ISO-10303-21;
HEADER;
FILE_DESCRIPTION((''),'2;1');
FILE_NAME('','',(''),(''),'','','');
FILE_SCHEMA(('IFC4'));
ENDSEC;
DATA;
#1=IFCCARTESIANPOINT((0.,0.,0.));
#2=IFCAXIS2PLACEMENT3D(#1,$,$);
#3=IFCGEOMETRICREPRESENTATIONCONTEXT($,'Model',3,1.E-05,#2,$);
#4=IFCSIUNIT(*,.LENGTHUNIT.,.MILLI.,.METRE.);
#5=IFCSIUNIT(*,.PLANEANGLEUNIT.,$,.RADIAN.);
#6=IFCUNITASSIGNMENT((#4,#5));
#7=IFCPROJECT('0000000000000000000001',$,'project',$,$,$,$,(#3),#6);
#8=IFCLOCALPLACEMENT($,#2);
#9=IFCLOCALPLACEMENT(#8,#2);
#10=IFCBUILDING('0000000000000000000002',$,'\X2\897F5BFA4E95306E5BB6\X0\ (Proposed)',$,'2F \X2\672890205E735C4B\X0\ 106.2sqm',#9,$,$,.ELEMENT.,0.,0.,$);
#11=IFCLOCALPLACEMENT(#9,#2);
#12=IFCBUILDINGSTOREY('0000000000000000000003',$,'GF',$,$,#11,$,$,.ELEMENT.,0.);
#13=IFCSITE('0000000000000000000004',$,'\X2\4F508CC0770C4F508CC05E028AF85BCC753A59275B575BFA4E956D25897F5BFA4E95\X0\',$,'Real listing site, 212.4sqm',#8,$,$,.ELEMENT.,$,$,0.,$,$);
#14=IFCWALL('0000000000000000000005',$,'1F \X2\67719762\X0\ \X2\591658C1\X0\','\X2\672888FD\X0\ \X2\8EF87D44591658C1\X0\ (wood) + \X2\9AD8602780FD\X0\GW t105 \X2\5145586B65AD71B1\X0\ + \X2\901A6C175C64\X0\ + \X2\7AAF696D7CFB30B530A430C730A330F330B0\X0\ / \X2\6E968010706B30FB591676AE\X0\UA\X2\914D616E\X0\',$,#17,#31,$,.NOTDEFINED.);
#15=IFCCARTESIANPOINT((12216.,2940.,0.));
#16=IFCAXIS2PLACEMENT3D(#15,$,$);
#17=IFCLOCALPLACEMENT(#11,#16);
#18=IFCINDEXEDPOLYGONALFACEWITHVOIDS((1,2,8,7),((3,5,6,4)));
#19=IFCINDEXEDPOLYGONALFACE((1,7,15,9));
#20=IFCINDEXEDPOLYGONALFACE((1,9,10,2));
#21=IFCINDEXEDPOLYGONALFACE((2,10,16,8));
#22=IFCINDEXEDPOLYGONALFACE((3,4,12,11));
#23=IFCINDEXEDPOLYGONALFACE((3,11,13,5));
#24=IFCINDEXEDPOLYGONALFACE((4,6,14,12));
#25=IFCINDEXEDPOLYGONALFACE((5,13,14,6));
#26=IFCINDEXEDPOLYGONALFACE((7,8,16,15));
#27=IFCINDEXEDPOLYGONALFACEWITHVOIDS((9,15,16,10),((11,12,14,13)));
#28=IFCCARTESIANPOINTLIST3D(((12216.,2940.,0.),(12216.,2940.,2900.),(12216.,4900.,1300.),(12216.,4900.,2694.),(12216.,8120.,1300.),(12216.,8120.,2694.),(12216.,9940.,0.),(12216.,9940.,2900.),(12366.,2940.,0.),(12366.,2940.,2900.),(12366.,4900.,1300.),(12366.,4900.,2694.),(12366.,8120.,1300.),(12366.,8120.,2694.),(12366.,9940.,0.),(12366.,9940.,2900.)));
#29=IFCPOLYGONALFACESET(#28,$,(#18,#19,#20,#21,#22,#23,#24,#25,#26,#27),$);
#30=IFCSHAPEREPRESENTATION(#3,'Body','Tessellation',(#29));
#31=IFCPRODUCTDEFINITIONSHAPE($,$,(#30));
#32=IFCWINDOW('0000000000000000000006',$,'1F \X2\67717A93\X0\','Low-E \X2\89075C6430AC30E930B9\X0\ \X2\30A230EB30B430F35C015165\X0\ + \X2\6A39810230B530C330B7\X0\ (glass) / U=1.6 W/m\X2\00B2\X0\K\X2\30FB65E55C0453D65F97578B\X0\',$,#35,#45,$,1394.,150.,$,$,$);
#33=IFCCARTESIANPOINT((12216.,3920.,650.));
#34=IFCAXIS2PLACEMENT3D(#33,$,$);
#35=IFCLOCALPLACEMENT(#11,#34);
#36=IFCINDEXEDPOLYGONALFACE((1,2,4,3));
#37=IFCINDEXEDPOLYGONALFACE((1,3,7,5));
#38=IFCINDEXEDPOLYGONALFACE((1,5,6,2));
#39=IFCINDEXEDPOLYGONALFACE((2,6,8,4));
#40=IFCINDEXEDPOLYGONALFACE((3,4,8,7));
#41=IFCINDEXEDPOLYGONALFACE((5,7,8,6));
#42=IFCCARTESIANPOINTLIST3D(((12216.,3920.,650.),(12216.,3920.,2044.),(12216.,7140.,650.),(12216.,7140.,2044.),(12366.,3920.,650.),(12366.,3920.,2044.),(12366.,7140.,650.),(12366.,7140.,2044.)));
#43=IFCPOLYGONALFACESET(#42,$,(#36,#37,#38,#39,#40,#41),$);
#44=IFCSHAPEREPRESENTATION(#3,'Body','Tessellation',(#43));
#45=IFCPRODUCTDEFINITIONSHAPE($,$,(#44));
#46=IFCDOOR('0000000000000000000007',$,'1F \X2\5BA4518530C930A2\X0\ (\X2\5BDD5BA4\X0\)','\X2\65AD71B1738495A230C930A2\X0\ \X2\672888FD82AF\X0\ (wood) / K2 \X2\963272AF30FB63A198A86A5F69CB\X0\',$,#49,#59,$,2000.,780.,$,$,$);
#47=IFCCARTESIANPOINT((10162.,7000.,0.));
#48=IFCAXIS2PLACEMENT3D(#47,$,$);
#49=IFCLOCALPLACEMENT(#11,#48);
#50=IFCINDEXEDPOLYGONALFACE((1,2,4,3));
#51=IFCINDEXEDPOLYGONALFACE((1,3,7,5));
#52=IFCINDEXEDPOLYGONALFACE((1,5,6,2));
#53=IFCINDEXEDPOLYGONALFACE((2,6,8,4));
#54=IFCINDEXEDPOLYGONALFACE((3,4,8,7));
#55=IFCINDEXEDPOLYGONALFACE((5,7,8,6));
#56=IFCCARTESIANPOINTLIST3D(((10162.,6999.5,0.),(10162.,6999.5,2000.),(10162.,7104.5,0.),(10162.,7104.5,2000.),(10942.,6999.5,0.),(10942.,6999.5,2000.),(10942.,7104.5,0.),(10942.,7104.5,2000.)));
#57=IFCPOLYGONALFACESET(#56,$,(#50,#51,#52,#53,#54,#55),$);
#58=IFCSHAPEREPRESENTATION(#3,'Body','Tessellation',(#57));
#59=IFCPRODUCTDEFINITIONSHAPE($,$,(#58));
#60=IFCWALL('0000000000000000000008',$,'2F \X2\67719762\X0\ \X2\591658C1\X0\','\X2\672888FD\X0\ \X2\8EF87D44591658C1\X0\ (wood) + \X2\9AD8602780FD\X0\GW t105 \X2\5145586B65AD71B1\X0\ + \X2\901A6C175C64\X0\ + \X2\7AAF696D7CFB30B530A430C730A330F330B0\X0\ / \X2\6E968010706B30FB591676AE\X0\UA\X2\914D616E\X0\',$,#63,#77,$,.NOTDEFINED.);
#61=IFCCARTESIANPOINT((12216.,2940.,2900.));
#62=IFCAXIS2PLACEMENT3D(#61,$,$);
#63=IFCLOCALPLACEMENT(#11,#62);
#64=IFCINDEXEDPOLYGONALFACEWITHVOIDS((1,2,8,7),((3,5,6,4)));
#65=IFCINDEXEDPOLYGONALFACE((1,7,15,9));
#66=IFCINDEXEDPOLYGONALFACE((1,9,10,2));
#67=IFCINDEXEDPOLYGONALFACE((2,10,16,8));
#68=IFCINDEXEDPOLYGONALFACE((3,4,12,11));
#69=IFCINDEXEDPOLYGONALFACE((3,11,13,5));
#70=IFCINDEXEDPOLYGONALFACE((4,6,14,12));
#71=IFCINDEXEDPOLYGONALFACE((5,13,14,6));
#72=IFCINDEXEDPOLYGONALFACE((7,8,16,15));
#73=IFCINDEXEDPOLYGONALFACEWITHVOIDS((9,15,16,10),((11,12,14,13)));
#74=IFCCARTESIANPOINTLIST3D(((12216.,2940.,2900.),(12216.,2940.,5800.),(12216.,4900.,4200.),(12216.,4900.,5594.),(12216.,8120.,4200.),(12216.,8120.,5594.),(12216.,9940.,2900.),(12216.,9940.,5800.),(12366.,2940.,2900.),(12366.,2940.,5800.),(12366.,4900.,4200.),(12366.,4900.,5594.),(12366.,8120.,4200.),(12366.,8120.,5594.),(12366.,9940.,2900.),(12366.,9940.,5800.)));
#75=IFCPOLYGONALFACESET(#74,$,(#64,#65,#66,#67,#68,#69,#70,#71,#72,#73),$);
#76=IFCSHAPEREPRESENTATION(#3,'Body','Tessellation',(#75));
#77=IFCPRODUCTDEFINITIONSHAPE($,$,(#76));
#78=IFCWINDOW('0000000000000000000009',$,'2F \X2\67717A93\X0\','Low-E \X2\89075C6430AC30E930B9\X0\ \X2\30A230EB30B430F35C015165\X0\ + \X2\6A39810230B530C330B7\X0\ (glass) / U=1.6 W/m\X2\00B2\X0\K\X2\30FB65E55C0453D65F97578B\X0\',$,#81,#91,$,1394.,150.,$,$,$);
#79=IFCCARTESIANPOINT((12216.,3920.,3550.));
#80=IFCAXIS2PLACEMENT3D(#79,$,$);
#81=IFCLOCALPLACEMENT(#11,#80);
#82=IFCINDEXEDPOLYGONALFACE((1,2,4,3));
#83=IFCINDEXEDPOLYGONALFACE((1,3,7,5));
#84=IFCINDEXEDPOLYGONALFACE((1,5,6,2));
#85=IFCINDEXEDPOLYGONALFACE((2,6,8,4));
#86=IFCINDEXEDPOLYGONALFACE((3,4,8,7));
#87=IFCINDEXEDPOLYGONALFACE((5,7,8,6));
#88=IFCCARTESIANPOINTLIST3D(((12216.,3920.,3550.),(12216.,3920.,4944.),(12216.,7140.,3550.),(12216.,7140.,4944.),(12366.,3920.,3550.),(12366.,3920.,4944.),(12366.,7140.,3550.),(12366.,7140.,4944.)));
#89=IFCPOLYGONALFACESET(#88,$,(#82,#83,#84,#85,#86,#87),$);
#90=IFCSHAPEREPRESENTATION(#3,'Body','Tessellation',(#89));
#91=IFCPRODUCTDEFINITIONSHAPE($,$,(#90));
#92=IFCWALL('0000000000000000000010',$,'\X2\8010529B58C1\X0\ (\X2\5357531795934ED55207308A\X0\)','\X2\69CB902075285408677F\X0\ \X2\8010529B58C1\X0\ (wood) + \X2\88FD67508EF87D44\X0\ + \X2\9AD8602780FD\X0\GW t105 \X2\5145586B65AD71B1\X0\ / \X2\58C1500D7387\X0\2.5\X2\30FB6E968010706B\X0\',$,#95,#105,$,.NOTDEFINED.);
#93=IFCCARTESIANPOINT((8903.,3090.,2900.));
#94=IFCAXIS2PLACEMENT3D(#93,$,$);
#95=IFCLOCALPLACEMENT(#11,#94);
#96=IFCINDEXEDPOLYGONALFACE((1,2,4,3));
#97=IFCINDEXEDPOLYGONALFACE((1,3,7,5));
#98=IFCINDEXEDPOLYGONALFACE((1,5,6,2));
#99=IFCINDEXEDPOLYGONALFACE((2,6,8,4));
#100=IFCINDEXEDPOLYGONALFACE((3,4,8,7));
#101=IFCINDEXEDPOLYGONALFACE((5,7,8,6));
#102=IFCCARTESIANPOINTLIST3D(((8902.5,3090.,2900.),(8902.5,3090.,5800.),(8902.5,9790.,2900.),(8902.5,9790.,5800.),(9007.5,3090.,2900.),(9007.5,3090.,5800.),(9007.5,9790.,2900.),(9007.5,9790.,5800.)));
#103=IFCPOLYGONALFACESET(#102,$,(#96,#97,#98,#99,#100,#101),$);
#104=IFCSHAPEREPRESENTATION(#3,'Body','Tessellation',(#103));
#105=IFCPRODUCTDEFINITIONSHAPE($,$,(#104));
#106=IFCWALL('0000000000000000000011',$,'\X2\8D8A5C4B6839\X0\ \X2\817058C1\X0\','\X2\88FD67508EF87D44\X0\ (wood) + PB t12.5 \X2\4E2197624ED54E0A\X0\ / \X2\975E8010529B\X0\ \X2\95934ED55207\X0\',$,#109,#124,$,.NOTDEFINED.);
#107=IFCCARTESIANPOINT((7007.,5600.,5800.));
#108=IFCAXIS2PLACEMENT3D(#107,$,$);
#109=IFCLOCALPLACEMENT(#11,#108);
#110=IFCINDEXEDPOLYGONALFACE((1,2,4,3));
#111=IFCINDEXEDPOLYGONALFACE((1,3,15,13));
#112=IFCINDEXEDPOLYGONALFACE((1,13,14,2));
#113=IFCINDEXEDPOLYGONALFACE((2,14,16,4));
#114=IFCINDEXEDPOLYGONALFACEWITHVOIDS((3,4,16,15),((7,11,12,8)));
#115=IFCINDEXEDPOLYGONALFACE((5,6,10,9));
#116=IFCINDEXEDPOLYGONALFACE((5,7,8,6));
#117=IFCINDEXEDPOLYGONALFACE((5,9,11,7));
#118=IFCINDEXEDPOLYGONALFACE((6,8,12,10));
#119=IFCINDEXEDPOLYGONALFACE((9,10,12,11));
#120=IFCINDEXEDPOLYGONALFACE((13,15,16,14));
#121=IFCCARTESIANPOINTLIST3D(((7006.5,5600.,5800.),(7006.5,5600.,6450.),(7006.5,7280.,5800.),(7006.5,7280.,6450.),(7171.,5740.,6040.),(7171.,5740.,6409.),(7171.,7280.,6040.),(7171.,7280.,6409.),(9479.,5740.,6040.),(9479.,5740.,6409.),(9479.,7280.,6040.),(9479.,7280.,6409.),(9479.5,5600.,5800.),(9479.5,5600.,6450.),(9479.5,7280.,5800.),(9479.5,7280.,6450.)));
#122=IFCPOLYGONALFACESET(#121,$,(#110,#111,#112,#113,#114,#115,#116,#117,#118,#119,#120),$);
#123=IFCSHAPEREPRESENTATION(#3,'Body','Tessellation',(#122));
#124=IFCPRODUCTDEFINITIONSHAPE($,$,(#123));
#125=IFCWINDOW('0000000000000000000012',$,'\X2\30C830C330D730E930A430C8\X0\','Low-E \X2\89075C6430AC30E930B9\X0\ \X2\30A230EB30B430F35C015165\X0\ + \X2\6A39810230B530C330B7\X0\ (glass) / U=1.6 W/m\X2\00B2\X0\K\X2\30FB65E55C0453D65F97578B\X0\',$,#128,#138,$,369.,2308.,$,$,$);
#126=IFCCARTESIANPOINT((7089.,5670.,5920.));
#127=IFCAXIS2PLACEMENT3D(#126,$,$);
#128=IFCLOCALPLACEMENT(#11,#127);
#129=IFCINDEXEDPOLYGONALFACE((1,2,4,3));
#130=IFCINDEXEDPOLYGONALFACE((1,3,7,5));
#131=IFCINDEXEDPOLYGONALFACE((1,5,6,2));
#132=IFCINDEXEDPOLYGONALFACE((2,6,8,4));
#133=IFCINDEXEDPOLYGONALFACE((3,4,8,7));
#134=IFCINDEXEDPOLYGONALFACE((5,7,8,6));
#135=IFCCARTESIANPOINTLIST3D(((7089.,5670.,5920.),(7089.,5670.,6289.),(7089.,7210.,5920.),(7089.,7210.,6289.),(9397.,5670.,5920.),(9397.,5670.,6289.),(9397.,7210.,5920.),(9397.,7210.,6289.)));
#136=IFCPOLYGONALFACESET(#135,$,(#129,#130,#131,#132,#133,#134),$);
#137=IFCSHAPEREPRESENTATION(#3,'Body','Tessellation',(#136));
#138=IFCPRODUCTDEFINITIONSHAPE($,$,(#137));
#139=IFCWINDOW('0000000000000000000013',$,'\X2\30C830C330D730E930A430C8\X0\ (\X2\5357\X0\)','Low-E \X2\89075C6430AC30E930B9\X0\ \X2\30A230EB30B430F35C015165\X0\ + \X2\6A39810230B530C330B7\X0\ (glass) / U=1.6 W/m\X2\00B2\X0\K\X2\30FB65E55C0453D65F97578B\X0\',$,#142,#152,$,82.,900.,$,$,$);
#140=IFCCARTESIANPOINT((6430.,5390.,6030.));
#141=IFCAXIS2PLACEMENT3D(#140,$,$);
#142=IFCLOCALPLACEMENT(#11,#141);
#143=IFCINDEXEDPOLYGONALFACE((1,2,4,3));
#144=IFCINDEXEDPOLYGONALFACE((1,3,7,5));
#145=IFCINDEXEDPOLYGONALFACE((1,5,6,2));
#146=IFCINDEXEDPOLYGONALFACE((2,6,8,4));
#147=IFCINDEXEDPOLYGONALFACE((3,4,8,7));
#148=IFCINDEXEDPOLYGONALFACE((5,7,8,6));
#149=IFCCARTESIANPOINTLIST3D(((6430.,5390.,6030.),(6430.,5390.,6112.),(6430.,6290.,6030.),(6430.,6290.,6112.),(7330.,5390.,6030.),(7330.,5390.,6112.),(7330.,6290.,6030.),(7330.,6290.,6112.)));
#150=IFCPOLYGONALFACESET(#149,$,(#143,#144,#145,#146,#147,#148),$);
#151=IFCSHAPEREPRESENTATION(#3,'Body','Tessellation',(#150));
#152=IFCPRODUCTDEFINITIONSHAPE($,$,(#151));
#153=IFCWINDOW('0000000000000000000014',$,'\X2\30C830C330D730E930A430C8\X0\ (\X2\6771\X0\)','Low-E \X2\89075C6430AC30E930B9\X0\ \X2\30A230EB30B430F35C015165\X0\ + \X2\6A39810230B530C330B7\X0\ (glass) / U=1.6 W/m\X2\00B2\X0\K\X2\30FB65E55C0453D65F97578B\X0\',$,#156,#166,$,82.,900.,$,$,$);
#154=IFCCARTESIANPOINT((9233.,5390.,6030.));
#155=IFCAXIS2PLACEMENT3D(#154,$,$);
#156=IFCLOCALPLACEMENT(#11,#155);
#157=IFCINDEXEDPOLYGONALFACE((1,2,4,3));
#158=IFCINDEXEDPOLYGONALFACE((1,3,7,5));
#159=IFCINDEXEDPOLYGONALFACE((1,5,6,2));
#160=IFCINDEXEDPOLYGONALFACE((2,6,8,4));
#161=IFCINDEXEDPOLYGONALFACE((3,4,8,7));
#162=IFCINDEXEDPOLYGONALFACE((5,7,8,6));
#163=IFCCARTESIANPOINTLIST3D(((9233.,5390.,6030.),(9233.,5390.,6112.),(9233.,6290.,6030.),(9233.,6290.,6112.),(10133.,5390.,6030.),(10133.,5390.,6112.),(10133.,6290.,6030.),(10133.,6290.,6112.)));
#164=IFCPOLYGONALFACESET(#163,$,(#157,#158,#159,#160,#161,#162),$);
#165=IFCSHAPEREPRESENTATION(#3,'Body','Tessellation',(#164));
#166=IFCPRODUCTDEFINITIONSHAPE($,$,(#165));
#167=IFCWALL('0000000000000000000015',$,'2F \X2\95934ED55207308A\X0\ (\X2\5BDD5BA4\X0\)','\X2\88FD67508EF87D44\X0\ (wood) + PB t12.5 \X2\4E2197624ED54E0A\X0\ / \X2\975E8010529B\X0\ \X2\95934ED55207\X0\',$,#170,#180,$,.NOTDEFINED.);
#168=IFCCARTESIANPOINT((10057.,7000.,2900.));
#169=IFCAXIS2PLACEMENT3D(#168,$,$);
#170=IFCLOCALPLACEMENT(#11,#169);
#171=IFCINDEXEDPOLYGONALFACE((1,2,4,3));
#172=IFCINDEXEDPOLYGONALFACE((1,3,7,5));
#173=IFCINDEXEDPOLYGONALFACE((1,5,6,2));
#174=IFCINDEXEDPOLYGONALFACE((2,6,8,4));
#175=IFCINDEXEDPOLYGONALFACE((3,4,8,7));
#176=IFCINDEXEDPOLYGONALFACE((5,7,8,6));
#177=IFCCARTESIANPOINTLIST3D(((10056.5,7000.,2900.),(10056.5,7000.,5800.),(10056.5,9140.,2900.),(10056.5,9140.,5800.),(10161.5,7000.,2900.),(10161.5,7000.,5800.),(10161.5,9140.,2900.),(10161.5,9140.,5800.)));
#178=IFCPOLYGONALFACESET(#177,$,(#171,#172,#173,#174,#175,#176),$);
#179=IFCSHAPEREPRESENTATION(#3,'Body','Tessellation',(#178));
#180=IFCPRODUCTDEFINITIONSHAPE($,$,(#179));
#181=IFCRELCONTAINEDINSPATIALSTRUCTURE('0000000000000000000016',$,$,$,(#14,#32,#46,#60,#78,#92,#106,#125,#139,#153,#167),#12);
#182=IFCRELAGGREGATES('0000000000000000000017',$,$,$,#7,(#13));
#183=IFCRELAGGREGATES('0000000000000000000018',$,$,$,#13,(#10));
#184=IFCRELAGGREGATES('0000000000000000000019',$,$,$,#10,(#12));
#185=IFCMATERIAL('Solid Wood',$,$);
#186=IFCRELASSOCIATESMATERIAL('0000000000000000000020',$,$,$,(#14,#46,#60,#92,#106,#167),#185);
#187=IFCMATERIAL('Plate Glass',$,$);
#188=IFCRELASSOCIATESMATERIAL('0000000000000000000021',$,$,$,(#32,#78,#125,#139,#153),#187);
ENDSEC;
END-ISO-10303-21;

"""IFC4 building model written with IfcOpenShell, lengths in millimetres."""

from ifc_helpers import new_model, si_unit, frame, frame_2d, origin, place, context, project, spatial, rectangle, extrude, material, element, fill, save


model = new_model("IFC4")

# Units and contexts
model_context = context("Model", 3, precision=1e-05, world=origin())
ifc_project = project(units=[si_unit("LENGTHUNIT", "METRE", prefix="MILLI"), si_unit("PLANEANGLEUNIT", "RADIAN")], contexts=[model_context])

# Site, building, storey
site_placement = place(None, origin())
site = spatial("IfcSite", under=ifc_project, at=site_placement, Name="佐賀県佐賀市諸富町大字寺井津西寺井", ObjectType="Real listing site, 212.4sqm", CompositionType="ELEMENT", RefElevation=0.0)
building_placement = place(site_placement, origin())
building = spatial("IfcBuilding", under=site, at=building_placement, Name="西寺井の家 (Proposed)", ObjectType="2F 木造平屋 106.2sqm", CompositionType="ELEMENT", ElevationOfRefHeight=0.0, ElevationOfTerrain=0.0)
storey_placement = place(building_placement, origin())
storey = spatial("IfcBuildingStorey", under=building, at=storey_placement, Name="GF", CompositionType="ELEMENT", Elevation=0.0)

# Wall, opening, window
ifc_material_1 = material(Name="Solid Wood")
wall_1_placement = place(storey_placement, frame((12216.0, 2940.0, 0.0)))
wall_1 = element("IfcWall", 1, at=wall_1_placement, inside=storey, material=ifc_material_1, Name="1F 東面 外壁", Description="木製 軸組外壁 (wood) + 高性能GW t105 充填断熱 + 通気層 + 窯業系サイディング / 準耐火・外皮UA配慮", PredefinedType="NOTDEFINED", context=model_context, shape_type="SweptSolid", body=[
    extrude(rectangle(XDim=150.0, YDim=7000.0, at=frame_2d((75.0, 3500.0))), frame((12216.0, 2940.0, 0.0)), (0.0, 0.0, 1.0), 2900.0),
])
opening_1_placement = place(storey_placement, frame((12216.0, 3920.0, 650.0)))
opening_1 = element("IfcOpeningElement", 2, at=opening_1_placement, cuts=wall_1, PredefinedType="NOTDEFINED", context=model_context, shape_type="SweptSolid", body=[
    extrude(rectangle(XDim=150.0, YDim=3220.0, at=frame_2d((75.0, 1610.0))), frame((12216.0, 3920.0, 650.0)), (0.0, 0.0, 1.0), 1394.0),
])
ifc_material_2 = material(Name="Plate Glass")
window_1_placement = place(storey_placement, frame((12216.0, 3920.0, 650.0)))
window_1 = element("IfcWindow", 3, at=window_1_placement, inside=storey, material=ifc_material_2, Name="1F 東窓", Description="Low-E 複層ガラス アルゴン封入 + 樹脂サッシ (glass) / U=1.6 W/m²K・日射取得型", OverallHeight=1394.0, OverallWidth=150.0, context=model_context, shape_type="SweptSolid", body=[
    extrude(rectangle(XDim=150.0, YDim=3220.0, at=frame_2d((75.0, 1610.0))), frame((12216.0, 3920.0, 650.0)), (0.0, 0.0, 1.0), 1394.0),
])
fill(opening_1, window_1)

# Door
door_1_placement = place(storey_placement, frame((10162.0, 7000.0, 0.0)))
element("IfcDoor", 4, at=door_1_placement, inside=storey, material=ifc_material_1, Name="1F 室内ドア (寝室)", Description="断熱玄関ドア 木製芯 (wood) / K2 防犯・採風機構", OverallHeight=2000.0, OverallWidth=780.0, context=model_context, shape_type="SweptSolid", body=[
    extrude(rectangle(XDim=780.0, YDim=105.0, at=frame_2d((390.0, 52.0))), frame((10162.0, 7000.0, 0.0)), (0.0, 0.0, 1.0), 2000.0),
])

# Wall, opening, window
wall_2_placement = place(storey_placement, frame((12216.0, 2940.0, 2900.0)))
wall_2 = element("IfcWall", 5, at=wall_2_placement, inside=storey, material=ifc_material_1, Name="2F 東面 外壁", Description="木製 軸組外壁 (wood) + 高性能GW t105 充填断熱 + 通気層 + 窯業系サイディング / 準耐火・外皮UA配慮", PredefinedType="NOTDEFINED", context=model_context, shape_type="SweptSolid", body=[
    extrude(rectangle(XDim=150.0, YDim=7000.0, at=frame_2d((75.0, 3500.0))), frame((12216.0, 2940.0, 2900.0)), (0.0, 0.0, 1.0), 2900.0),
])
opening_2_placement = place(storey_placement, frame((12216.0, 3920.0, 3550.0)))
opening_2 = element("IfcOpeningElement", 6, at=opening_2_placement, cuts=wall_2, PredefinedType="NOTDEFINED", context=model_context, shape_type="SweptSolid", body=[
    extrude(rectangle(XDim=150.0, YDim=3220.0, at=frame_2d((75.0, 1610.0))), frame((12216.0, 3920.0, 3550.0)), (0.0, 0.0, 1.0), 1394.0),
])
window_2_placement = place(storey_placement, frame((12216.0, 3920.0, 3550.0)))
window_2 = element("IfcWindow", 7, at=window_2_placement, inside=storey, material=ifc_material_2, Name="2F 東窓", Description="Low-E 複層ガラス アルゴン封入 + 樹脂サッシ (glass) / U=1.6 W/m²K・日射取得型", OverallHeight=1394.0, OverallWidth=150.0, context=model_context, shape_type="SweptSolid", body=[
    extrude(rectangle(XDim=150.0, YDim=3220.0, at=frame_2d((75.0, 1610.0))), frame((12216.0, 3920.0, 3550.0)), (0.0, 0.0, 1.0), 1394.0),
])
fill(opening_2, window_2)

# Wall
wall_3_placement = place(storey_placement, frame((8903.0, 3090.0, 2900.0)))
element("IfcWall", 8, at=wall_3_placement, inside=storey, material=ifc_material_1, Name="耐力壁 (南北間仕切り)", Description="構造用合板 耐力壁 (wood) + 製材軸組 + 高性能GW t105 充填断熱 / 壁倍率2.5・準耐火", PredefinedType="NOTDEFINED", context=model_context, shape_type="SweptSolid", body=[
    extrude(rectangle(XDim=105.0, YDim=6700.0, at=frame_2d((52.0, 3350.0))), frame((8903.0, 3090.0, 2900.0)), (0.0, 0.0, 1.0), 2900.0),
])

# Wall, openings, windows
wall_4_placement = place(storey_placement, frame((7007.0, 5600.0, 5800.0)))
wall_4 = element("IfcWall", 9, at=wall_4_placement, inside=storey, material=ifc_material_1, Name="越屋根 腰壁", Description="製材軸組 (wood) + PB t12.5 両面仕上 / 非耐力 間仕切", PredefinedType="NOTDEFINED", context=model_context, shape_type="SweptSolid", body=[
    extrude(rectangle(XDim=2473.0, YDim=1680.0, at=frame_2d((1236.0, 840.0))), frame((7007.0, 5600.0, 5800.0)), (0.0, 0.0, 1.0), 650.0),
])
opening_3_placement = place(storey_placement, frame((7089.0, 5670.0, 5920.0)))
opening_3 = element("IfcOpeningElement", 10, at=opening_3_placement, cuts=wall_4, PredefinedType="NOTDEFINED", context=model_context, shape_type="SweptSolid", body=[
    extrude(rectangle(XDim=2308.0, YDim=1540.0, at=frame_2d((1154.0, 770.0))), frame((7089.0, 5670.0, 5920.0)), (0.0, 0.0, 1.0), 369.0),
])
opening_4_placement = place(storey_placement, frame((6430.0, 5390.0, 6030.0)))
opening_4 = element("IfcOpeningElement", 11, at=opening_4_placement, cuts=wall_4, PredefinedType="NOTDEFINED", context=model_context, shape_type="SweptSolid", body=[
    extrude(rectangle(XDim=900.0, YDim=900.0, at=frame_2d((450.0, 450.0))), frame((6430.0, 5390.0, 6030.0)), (0.0, 0.0, 1.0), 82.0),
])
opening_5_placement = place(storey_placement, frame((9233.0, 5390.0, 6030.0)))
opening_5 = element("IfcOpeningElement", 12, at=opening_5_placement, cuts=wall_4, PredefinedType="NOTDEFINED", context=model_context, shape_type="SweptSolid", body=[
    extrude(rectangle(XDim=900.0, YDim=900.0, at=frame_2d((450.0, 450.0))), frame((9233.0, 5390.0, 6030.0)), (0.0, 0.0, 1.0), 82.0),
])
window_3_placement = place(storey_placement, frame((7089.0, 5670.0, 5920.0)))
window_3 = element("IfcWindow", 13, at=window_3_placement, inside=storey, material=ifc_material_2, Name="トップライト", Description="Low-E 複層ガラス アルゴン封入 + 樹脂サッシ (glass) / U=1.6 W/m²K・日射取得型", OverallHeight=369.0, OverallWidth=2308.0, context=model_context, shape_type="SweptSolid", body=[
    extrude(rectangle(XDim=2308.0, YDim=1540.0, at=frame_2d((1154.0, 770.0))), frame((7089.0, 5670.0, 5920.0)), (0.0, 0.0, 1.0), 369.0),
])
fill(opening_3, window_3)
window_4_placement = place(storey_placement, frame((6430.0, 5390.0, 6030.0)))
window_4 = element("IfcWindow", 14, at=window_4_placement, inside=storey, material=ifc_material_2, Name="トップライト (南)", Description="Low-E 複層ガラス アルゴン封入 + 樹脂サッシ (glass) / U=1.6 W/m²K・日射取得型", OverallHeight=82.0, OverallWidth=900.0, context=model_context, shape_type="SweptSolid", body=[
    extrude(rectangle(XDim=900.0, YDim=900.0, at=frame_2d((450.0, 450.0))), frame((6430.0, 5390.0, 6030.0)), (0.0, 0.0, 1.0), 82.0),
])
fill(opening_4, window_4)
window_5_placement = place(storey_placement, frame((9233.0, 5390.0, 6030.0)))
window_5 = element("IfcWindow", 15, at=window_5_placement, inside=storey, material=ifc_material_2, Name="トップライト (東)", Description="Low-E 複層ガラス アルゴン封入 + 樹脂サッシ (glass) / U=1.6 W/m²K・日射取得型", OverallHeight=82.0, OverallWidth=900.0, context=model_context, shape_type="SweptSolid", body=[
    extrude(rectangle(XDim=900.0, YDim=900.0, at=frame_2d((450.0, 450.0))), frame((9233.0, 5390.0, 6030.0)), (0.0, 0.0, 1.0), 82.0),
])
fill(opening_5, window_5)

# Wall
wall_5_placement = place(storey_placement, frame((10057.0, 7000.0, 2900.0)))
element("IfcWall", 16, at=wall_5_placement, inside=storey, material=ifc_material_1, Name="2F 間仕切り (寝室)", Description="製材軸組 (wood) + PB t12.5 両面仕上 / 非耐力 間仕切", PredefinedType="NOTDEFINED", context=model_context, shape_type="SweptSolid", body=[
    extrude(rectangle(XDim=105.0, YDim=2140.0, at=frame_2d((52.0, 1070.0))), frame((10057.0, 7000.0, 2900.0)), (0.0, 0.0, 1.0), 2900.0),
])

save(model, "model.ifc")
